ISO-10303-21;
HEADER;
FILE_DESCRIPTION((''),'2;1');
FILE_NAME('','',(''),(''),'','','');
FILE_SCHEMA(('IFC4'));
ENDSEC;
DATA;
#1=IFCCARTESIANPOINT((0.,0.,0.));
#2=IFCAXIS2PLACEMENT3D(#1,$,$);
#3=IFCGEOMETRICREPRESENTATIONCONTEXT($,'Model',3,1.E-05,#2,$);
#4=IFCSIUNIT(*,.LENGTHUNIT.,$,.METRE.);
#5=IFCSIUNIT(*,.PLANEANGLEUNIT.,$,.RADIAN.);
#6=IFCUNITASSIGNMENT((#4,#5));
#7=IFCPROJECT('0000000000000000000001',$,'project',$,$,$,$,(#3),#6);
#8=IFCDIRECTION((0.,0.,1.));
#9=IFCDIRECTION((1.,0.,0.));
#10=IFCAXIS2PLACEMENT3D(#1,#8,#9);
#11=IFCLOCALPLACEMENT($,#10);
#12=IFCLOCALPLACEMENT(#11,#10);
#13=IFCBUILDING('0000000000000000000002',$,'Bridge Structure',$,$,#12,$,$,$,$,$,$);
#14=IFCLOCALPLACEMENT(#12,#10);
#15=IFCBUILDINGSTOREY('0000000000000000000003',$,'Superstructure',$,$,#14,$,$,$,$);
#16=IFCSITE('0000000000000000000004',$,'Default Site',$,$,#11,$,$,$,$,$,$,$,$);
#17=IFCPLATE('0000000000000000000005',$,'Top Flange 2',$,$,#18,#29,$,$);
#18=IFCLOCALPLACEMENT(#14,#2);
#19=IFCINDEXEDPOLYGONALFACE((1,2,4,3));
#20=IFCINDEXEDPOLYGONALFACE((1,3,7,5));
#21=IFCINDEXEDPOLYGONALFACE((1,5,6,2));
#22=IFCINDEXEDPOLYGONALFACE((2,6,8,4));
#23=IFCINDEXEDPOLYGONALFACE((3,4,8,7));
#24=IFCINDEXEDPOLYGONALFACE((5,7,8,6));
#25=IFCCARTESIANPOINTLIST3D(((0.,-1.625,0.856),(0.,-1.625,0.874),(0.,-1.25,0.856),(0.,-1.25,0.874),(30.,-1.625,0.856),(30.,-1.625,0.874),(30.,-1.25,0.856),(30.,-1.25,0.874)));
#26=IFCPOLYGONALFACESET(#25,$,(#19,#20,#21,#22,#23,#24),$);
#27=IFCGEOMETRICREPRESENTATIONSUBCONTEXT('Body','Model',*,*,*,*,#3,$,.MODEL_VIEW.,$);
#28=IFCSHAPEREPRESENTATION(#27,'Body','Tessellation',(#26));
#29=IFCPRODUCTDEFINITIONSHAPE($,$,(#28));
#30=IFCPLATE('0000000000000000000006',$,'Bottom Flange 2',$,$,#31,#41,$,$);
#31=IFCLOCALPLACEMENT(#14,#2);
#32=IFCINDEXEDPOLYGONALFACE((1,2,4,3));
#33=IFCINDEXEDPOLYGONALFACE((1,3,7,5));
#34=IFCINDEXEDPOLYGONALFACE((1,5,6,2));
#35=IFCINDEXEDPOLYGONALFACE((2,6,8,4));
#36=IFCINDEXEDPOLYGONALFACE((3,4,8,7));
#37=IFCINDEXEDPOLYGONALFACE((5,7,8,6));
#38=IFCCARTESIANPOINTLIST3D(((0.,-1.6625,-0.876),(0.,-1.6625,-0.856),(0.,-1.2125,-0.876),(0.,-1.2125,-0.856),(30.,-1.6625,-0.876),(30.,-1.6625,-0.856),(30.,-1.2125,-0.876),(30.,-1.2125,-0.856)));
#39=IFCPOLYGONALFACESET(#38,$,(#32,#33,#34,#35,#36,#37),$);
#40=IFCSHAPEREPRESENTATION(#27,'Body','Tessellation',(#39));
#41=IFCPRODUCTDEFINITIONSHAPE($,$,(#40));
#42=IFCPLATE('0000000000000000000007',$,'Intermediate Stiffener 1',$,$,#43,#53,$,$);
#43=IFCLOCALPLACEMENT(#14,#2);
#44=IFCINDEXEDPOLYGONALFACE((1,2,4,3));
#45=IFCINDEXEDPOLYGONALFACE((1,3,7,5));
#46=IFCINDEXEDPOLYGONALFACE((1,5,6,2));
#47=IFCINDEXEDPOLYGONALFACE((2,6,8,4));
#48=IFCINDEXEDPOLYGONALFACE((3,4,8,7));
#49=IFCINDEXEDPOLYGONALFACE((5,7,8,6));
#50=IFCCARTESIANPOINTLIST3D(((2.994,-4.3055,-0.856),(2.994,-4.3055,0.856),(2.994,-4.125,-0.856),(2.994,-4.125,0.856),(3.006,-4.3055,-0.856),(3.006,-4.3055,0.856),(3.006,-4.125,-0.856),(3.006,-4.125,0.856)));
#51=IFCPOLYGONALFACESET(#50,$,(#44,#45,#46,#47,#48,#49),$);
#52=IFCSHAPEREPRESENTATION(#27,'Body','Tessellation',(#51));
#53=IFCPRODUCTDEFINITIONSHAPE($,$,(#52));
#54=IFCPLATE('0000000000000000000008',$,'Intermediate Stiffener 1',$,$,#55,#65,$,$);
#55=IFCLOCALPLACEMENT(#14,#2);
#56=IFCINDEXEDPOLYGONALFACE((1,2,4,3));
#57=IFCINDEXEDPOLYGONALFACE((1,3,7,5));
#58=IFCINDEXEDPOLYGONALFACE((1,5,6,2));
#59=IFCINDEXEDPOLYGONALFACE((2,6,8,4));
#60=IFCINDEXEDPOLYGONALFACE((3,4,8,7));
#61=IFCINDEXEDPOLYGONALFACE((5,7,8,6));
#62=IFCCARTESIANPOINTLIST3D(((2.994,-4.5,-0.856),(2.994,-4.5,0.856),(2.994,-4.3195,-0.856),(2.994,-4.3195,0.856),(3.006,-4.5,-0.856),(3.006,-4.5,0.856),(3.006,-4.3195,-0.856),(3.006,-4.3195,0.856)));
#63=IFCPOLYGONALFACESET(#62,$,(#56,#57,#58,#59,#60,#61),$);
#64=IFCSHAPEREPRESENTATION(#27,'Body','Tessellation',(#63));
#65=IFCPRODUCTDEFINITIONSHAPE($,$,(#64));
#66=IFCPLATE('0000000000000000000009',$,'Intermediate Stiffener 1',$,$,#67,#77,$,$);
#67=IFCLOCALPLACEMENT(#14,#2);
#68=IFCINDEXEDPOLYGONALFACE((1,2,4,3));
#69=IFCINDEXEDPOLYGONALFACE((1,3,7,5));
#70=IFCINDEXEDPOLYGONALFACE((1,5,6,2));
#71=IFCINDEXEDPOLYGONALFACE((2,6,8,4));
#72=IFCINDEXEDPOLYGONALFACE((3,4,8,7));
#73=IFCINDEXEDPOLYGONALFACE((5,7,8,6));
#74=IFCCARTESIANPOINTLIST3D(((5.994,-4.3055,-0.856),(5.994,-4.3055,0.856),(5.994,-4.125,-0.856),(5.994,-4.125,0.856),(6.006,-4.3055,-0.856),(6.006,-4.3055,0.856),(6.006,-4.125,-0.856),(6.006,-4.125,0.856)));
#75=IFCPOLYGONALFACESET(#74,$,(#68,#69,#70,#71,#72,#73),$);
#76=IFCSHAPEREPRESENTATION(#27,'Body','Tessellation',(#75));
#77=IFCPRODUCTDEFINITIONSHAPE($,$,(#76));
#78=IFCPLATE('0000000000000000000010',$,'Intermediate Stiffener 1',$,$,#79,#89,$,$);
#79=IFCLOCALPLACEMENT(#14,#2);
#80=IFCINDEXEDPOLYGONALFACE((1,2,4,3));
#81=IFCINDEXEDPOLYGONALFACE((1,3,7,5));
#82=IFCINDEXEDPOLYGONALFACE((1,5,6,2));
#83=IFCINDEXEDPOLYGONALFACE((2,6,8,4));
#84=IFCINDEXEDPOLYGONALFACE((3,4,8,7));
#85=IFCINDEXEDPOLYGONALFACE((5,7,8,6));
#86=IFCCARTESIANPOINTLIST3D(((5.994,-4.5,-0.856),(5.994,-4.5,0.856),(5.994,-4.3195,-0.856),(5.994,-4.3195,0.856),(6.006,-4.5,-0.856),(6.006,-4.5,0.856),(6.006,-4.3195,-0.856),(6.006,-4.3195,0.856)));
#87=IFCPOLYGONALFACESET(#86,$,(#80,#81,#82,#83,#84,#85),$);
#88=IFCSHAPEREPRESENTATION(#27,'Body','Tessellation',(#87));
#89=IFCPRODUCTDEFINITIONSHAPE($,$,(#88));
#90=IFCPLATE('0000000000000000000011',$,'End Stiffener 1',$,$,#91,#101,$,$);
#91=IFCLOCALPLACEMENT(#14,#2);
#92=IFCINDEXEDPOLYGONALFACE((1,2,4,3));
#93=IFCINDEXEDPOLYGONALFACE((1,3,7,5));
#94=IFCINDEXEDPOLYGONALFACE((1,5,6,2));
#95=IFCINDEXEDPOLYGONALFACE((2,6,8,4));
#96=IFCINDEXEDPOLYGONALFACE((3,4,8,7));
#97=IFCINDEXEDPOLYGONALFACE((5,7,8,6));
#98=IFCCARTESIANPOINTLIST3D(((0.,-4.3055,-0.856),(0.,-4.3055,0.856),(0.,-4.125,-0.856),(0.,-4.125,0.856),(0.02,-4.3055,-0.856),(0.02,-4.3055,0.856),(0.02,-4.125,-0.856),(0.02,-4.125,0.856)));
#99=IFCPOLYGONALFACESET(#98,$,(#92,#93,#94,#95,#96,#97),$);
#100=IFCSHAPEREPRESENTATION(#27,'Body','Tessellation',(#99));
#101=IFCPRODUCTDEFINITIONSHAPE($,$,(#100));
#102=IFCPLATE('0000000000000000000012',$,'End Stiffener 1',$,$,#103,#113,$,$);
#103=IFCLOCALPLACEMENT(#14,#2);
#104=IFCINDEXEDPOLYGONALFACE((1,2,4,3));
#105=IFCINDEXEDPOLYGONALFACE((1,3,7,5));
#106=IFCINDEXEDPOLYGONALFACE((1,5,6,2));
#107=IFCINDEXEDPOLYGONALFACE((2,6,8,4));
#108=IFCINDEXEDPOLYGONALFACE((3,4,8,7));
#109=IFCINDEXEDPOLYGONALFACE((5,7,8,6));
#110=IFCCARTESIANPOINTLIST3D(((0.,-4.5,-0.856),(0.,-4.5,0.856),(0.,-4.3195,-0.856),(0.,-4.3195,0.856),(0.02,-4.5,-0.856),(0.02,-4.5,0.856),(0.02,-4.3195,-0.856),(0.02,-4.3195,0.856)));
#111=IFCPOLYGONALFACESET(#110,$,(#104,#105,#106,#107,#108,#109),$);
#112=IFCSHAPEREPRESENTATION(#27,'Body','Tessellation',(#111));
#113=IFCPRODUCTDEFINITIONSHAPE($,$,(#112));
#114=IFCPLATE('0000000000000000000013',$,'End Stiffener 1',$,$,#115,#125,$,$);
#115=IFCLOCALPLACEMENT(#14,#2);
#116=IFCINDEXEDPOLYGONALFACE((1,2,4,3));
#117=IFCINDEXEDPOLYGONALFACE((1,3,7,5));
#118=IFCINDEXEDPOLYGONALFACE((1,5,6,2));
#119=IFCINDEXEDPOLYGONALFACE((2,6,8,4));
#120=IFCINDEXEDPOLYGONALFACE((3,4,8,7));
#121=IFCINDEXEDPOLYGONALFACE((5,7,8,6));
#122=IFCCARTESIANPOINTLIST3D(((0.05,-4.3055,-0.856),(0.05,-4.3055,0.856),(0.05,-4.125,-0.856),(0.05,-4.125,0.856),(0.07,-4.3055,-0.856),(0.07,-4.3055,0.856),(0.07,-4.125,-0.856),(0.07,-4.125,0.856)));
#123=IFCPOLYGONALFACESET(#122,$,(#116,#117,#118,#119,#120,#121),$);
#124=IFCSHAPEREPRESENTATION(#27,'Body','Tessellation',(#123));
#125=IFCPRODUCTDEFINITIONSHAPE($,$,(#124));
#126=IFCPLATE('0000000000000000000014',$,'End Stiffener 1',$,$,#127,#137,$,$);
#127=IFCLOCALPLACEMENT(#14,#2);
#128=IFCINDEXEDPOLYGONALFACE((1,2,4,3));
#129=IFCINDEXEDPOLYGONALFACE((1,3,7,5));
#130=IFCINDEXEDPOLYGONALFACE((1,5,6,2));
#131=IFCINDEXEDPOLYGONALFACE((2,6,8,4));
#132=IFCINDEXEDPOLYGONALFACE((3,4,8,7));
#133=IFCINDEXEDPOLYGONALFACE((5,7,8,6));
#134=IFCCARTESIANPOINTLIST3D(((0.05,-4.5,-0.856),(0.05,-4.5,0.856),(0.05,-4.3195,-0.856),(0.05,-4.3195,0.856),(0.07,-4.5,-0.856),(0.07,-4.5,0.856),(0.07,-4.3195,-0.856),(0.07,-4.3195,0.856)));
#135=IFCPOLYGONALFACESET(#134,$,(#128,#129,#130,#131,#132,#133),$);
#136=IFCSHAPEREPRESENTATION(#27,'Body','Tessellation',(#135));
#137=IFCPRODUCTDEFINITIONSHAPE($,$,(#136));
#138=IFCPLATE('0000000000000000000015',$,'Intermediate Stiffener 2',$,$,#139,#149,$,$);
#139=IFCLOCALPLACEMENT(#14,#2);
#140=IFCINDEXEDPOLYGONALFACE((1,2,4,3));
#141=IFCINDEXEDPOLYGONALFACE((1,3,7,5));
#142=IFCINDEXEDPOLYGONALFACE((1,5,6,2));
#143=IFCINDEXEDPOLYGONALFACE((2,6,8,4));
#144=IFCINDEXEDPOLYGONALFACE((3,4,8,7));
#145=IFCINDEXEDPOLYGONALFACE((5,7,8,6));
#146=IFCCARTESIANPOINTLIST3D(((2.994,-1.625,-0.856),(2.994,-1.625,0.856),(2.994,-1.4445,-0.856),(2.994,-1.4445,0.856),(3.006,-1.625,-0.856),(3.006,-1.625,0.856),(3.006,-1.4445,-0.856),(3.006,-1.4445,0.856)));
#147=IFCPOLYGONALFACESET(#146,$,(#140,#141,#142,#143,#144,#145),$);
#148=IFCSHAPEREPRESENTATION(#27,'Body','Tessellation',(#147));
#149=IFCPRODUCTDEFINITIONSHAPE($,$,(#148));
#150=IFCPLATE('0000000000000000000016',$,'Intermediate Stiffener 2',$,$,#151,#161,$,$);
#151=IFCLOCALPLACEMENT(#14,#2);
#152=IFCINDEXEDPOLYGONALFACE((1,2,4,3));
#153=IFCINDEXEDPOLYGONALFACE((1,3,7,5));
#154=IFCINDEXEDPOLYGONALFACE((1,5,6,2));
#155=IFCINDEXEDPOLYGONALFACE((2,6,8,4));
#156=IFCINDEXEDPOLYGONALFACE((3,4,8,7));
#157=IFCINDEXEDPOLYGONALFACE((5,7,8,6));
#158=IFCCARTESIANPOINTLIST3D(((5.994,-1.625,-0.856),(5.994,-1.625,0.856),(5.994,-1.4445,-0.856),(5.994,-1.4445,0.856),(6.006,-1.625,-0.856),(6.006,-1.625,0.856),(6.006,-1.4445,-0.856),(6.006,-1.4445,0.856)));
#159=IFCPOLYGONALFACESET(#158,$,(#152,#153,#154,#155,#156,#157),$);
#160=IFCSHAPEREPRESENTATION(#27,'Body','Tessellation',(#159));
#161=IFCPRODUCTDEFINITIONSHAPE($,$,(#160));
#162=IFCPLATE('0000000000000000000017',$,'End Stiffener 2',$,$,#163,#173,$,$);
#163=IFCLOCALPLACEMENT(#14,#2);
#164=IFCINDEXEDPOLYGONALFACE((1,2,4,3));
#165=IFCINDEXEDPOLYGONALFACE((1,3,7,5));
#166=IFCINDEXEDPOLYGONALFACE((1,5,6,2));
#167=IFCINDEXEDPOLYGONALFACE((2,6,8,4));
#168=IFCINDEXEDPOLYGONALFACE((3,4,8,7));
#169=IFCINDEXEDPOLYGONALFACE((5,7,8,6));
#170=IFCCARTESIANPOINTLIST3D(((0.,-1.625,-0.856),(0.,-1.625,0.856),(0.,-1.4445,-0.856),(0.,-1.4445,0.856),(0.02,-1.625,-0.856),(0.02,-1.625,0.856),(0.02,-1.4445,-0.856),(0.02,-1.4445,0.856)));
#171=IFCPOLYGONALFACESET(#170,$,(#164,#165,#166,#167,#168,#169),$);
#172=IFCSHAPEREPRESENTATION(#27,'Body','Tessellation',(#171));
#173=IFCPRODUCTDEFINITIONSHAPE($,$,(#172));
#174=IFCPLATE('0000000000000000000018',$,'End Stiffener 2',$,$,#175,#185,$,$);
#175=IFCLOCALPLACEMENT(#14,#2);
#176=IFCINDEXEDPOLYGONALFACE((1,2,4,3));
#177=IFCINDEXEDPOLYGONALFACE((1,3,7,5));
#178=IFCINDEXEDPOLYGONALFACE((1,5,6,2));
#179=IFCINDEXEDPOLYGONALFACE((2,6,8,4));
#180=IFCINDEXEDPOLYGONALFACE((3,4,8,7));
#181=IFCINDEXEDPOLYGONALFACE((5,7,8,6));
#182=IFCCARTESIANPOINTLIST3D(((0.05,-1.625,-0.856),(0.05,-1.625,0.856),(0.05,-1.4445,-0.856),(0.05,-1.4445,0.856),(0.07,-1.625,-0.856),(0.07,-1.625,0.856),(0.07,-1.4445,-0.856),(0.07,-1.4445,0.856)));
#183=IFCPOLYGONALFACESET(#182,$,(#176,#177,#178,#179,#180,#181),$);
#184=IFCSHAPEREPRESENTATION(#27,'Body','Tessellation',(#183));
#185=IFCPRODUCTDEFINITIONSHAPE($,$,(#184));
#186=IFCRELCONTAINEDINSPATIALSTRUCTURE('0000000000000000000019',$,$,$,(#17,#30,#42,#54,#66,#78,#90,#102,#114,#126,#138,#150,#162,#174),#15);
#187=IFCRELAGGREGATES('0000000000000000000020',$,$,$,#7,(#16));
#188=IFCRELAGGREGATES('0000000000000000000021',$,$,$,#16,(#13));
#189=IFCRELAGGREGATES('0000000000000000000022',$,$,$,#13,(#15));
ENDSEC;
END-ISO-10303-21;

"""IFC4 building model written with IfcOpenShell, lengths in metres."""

from ifc_helpers import new_model, si_unit, frame, origin, origin_with_axes, origin_2d_with_axis, place, context, subcontext, project, spatial, rectangle, extrude, element, save


model = new_model("IFC4")

# Units and contexts
model_context = context("Model", 3, precision=1e-05, world=origin())
body_context = subcontext(model_context, "Body", "Model", "MODEL_VIEW")
ifc_project = project(units=[si_unit("LENGTHUNIT", "METRE"), si_unit("PLANEANGLEUNIT", "RADIAN")], contexts=[model_context])

# Site, building, storey
site_placement = place(None, origin_with_axes())
site = spatial("IfcSite", under=ifc_project, at=site_placement, Name="Default Site")
building_placement = place(site_placement, origin_with_axes())
building = spatial("IfcBuilding", under=site, at=building_placement, Name="Bridge Structure")
storey_placement = place(building_placement, origin_with_axes())
storey = spatial("IfcBuildingStorey", under=building, at=storey_placement, Name="Superstructure")

# Plates
plate_1_placement = place(storey_placement, frame((0.0, -1.4375, 0.865), z_axis=(1.0, 0.0, 0.0), x_axis=(0.0, 1.0, 0.0)))
element("IfcPlate", 1, at=plate_1_placement, inside=storey, Name="Top Flange 2", context=body_context, shape_type="SweptSolid", body=[
    extrude(rectangle(XDim=0.375, YDim=0.018, at=origin_2d_with_axis()), origin_with_axes(), (0.0, 0.0, 1.0), 30.0),
])
plate_2_placement = place(storey_placement, frame((0.0, -1.4375, -0.866), z_axis=(1.0, 0.0, 0.0), x_axis=(0.0, 1.0, 0.0)))
element("IfcPlate", 2, at=plate_2_placement, inside=storey, Name="Bottom Flange 2", context=body_context, shape_type="SweptSolid", body=[
    extrude(rectangle(XDim=0.45, YDim=0.02, at=origin_2d_with_axis()), origin_with_axes(), (0.0, 0.0, 1.0), 30.0),
])
for number, where, z_axis, x_axis, name in (
    (3, (3.0, -4.2153, -0.856), (0.0, 0.0, 1.0), (1.0, 0.0, 0.0), "Intermediate Stiffener 1"),
    (4, (3.0, -4.4097, -0.856), (0.0, 0.0, 1.0), (1.0, 0.0, 0.0), "Intermediate Stiffener 1"),
    (5, (6.0, -4.2153, -0.856), (0.0, 0.0, 1.0), (1.0, 0.0, 0.0), "Intermediate Stiffener 1"),
    (6, (6.0, -4.4097, -0.856), (0.0, 0.0, 1.0), (1.0, 0.0, 0.0), "Intermediate Stiffener 1"),
):
    element("IfcPlate", number, at=place(storey_placement, frame(where, z_axis=z_axis, x_axis=x_axis)), inside=storey, Name=name, context=body_context, shape_type="SweptSolid", body=[
        extrude(rectangle(XDim=0.012, YDim=0.1805, at=origin_2d_with_axis()), origin_with_axes(), (0.0, 0.0, 1.0), 1.712),
    ])
for number, where, z_axis, x_axis, name in (
    (7, (0.01, -4.2153, -0.856), (0.0, 0.0, 1.0), (1.0, 0.0, 0.0), "End Stiffener 1"),
    (8, (0.01, -4.4097, -0.856), (0.0, 0.0, 1.0), (1.0, 0.0, 0.0), "End Stiffener 1"),
    (9, (0.06, -4.2153, -0.856), (0.0, 0.0, 1.0), (1.0, 0.0, 0.0), "End Stiffener 1"),
    (10, (0.06, -4.4097, -0.856), (0.0, 0.0, 1.0), (1.0, 0.0, 0.0), "End Stiffener 1"),
):
    element("IfcPlate", number, at=place(storey_placement, frame(where, z_axis=z_axis, x_axis=x_axis)), inside=storey, Name=name, context=body_context, shape_type="SweptSolid", body=[
        extrude(rectangle(XDim=0.02, YDim=0.1805, at=origin_2d_with_axis()), origin_with_axes(), (0.0, 0.0, 1.0), 1.712),
    ])
for number, where, z_axis, x_axis, name in (
    (11, (3.0, -1.5348, -0.856), (0.0, 0.0, 1.0), (1.0, 0.0, 0.0), "Intermediate Stiffener 2"),
    (12, (6.0, -1.5348, -0.856), (0.0, 0.0, 1.0), (1.0, 0.0, 0.0), "Intermediate Stiffener 2"),
):
    element("IfcPlate", number, at=place(storey_placement, frame(where, z_axis=z_axis, x_axis=x_axis)), inside=storey, Name=name, context=body_context, shape_type="SweptSolid", body=[
        extrude(rectangle(XDim=0.012, YDim=0.1805, at=origin_2d_with_axis()), origin_with_axes(), (0.0, 0.0, 1.0), 1.712),
    ])
for number, where, z_axis, x_axis, name in (
    (13, (0.01, -1.5348, -0.856), (0.0, 0.0, 1.0), (1.0, 0.0, 0.0), "End Stiffener 2"),
    (14, (0.06, -1.5348, -0.856), (0.0, 0.0, 1.0), (1.0, 0.0, 0.0), "End Stiffener 2"),
):
    element("IfcPlate", number, at=place(storey_placement, frame(where, z_axis=z_axis, x_axis=x_axis)), inside=storey, Name=name, context=body_context, shape_type="SweptSolid", body=[
        extrude(rectangle(XDim=0.02, YDim=0.1805, at=origin_2d_with_axis()), origin_with_axes(), (0.0, 0.0, 1.0), 1.712),
    ])

save(model, "model.ifc")
